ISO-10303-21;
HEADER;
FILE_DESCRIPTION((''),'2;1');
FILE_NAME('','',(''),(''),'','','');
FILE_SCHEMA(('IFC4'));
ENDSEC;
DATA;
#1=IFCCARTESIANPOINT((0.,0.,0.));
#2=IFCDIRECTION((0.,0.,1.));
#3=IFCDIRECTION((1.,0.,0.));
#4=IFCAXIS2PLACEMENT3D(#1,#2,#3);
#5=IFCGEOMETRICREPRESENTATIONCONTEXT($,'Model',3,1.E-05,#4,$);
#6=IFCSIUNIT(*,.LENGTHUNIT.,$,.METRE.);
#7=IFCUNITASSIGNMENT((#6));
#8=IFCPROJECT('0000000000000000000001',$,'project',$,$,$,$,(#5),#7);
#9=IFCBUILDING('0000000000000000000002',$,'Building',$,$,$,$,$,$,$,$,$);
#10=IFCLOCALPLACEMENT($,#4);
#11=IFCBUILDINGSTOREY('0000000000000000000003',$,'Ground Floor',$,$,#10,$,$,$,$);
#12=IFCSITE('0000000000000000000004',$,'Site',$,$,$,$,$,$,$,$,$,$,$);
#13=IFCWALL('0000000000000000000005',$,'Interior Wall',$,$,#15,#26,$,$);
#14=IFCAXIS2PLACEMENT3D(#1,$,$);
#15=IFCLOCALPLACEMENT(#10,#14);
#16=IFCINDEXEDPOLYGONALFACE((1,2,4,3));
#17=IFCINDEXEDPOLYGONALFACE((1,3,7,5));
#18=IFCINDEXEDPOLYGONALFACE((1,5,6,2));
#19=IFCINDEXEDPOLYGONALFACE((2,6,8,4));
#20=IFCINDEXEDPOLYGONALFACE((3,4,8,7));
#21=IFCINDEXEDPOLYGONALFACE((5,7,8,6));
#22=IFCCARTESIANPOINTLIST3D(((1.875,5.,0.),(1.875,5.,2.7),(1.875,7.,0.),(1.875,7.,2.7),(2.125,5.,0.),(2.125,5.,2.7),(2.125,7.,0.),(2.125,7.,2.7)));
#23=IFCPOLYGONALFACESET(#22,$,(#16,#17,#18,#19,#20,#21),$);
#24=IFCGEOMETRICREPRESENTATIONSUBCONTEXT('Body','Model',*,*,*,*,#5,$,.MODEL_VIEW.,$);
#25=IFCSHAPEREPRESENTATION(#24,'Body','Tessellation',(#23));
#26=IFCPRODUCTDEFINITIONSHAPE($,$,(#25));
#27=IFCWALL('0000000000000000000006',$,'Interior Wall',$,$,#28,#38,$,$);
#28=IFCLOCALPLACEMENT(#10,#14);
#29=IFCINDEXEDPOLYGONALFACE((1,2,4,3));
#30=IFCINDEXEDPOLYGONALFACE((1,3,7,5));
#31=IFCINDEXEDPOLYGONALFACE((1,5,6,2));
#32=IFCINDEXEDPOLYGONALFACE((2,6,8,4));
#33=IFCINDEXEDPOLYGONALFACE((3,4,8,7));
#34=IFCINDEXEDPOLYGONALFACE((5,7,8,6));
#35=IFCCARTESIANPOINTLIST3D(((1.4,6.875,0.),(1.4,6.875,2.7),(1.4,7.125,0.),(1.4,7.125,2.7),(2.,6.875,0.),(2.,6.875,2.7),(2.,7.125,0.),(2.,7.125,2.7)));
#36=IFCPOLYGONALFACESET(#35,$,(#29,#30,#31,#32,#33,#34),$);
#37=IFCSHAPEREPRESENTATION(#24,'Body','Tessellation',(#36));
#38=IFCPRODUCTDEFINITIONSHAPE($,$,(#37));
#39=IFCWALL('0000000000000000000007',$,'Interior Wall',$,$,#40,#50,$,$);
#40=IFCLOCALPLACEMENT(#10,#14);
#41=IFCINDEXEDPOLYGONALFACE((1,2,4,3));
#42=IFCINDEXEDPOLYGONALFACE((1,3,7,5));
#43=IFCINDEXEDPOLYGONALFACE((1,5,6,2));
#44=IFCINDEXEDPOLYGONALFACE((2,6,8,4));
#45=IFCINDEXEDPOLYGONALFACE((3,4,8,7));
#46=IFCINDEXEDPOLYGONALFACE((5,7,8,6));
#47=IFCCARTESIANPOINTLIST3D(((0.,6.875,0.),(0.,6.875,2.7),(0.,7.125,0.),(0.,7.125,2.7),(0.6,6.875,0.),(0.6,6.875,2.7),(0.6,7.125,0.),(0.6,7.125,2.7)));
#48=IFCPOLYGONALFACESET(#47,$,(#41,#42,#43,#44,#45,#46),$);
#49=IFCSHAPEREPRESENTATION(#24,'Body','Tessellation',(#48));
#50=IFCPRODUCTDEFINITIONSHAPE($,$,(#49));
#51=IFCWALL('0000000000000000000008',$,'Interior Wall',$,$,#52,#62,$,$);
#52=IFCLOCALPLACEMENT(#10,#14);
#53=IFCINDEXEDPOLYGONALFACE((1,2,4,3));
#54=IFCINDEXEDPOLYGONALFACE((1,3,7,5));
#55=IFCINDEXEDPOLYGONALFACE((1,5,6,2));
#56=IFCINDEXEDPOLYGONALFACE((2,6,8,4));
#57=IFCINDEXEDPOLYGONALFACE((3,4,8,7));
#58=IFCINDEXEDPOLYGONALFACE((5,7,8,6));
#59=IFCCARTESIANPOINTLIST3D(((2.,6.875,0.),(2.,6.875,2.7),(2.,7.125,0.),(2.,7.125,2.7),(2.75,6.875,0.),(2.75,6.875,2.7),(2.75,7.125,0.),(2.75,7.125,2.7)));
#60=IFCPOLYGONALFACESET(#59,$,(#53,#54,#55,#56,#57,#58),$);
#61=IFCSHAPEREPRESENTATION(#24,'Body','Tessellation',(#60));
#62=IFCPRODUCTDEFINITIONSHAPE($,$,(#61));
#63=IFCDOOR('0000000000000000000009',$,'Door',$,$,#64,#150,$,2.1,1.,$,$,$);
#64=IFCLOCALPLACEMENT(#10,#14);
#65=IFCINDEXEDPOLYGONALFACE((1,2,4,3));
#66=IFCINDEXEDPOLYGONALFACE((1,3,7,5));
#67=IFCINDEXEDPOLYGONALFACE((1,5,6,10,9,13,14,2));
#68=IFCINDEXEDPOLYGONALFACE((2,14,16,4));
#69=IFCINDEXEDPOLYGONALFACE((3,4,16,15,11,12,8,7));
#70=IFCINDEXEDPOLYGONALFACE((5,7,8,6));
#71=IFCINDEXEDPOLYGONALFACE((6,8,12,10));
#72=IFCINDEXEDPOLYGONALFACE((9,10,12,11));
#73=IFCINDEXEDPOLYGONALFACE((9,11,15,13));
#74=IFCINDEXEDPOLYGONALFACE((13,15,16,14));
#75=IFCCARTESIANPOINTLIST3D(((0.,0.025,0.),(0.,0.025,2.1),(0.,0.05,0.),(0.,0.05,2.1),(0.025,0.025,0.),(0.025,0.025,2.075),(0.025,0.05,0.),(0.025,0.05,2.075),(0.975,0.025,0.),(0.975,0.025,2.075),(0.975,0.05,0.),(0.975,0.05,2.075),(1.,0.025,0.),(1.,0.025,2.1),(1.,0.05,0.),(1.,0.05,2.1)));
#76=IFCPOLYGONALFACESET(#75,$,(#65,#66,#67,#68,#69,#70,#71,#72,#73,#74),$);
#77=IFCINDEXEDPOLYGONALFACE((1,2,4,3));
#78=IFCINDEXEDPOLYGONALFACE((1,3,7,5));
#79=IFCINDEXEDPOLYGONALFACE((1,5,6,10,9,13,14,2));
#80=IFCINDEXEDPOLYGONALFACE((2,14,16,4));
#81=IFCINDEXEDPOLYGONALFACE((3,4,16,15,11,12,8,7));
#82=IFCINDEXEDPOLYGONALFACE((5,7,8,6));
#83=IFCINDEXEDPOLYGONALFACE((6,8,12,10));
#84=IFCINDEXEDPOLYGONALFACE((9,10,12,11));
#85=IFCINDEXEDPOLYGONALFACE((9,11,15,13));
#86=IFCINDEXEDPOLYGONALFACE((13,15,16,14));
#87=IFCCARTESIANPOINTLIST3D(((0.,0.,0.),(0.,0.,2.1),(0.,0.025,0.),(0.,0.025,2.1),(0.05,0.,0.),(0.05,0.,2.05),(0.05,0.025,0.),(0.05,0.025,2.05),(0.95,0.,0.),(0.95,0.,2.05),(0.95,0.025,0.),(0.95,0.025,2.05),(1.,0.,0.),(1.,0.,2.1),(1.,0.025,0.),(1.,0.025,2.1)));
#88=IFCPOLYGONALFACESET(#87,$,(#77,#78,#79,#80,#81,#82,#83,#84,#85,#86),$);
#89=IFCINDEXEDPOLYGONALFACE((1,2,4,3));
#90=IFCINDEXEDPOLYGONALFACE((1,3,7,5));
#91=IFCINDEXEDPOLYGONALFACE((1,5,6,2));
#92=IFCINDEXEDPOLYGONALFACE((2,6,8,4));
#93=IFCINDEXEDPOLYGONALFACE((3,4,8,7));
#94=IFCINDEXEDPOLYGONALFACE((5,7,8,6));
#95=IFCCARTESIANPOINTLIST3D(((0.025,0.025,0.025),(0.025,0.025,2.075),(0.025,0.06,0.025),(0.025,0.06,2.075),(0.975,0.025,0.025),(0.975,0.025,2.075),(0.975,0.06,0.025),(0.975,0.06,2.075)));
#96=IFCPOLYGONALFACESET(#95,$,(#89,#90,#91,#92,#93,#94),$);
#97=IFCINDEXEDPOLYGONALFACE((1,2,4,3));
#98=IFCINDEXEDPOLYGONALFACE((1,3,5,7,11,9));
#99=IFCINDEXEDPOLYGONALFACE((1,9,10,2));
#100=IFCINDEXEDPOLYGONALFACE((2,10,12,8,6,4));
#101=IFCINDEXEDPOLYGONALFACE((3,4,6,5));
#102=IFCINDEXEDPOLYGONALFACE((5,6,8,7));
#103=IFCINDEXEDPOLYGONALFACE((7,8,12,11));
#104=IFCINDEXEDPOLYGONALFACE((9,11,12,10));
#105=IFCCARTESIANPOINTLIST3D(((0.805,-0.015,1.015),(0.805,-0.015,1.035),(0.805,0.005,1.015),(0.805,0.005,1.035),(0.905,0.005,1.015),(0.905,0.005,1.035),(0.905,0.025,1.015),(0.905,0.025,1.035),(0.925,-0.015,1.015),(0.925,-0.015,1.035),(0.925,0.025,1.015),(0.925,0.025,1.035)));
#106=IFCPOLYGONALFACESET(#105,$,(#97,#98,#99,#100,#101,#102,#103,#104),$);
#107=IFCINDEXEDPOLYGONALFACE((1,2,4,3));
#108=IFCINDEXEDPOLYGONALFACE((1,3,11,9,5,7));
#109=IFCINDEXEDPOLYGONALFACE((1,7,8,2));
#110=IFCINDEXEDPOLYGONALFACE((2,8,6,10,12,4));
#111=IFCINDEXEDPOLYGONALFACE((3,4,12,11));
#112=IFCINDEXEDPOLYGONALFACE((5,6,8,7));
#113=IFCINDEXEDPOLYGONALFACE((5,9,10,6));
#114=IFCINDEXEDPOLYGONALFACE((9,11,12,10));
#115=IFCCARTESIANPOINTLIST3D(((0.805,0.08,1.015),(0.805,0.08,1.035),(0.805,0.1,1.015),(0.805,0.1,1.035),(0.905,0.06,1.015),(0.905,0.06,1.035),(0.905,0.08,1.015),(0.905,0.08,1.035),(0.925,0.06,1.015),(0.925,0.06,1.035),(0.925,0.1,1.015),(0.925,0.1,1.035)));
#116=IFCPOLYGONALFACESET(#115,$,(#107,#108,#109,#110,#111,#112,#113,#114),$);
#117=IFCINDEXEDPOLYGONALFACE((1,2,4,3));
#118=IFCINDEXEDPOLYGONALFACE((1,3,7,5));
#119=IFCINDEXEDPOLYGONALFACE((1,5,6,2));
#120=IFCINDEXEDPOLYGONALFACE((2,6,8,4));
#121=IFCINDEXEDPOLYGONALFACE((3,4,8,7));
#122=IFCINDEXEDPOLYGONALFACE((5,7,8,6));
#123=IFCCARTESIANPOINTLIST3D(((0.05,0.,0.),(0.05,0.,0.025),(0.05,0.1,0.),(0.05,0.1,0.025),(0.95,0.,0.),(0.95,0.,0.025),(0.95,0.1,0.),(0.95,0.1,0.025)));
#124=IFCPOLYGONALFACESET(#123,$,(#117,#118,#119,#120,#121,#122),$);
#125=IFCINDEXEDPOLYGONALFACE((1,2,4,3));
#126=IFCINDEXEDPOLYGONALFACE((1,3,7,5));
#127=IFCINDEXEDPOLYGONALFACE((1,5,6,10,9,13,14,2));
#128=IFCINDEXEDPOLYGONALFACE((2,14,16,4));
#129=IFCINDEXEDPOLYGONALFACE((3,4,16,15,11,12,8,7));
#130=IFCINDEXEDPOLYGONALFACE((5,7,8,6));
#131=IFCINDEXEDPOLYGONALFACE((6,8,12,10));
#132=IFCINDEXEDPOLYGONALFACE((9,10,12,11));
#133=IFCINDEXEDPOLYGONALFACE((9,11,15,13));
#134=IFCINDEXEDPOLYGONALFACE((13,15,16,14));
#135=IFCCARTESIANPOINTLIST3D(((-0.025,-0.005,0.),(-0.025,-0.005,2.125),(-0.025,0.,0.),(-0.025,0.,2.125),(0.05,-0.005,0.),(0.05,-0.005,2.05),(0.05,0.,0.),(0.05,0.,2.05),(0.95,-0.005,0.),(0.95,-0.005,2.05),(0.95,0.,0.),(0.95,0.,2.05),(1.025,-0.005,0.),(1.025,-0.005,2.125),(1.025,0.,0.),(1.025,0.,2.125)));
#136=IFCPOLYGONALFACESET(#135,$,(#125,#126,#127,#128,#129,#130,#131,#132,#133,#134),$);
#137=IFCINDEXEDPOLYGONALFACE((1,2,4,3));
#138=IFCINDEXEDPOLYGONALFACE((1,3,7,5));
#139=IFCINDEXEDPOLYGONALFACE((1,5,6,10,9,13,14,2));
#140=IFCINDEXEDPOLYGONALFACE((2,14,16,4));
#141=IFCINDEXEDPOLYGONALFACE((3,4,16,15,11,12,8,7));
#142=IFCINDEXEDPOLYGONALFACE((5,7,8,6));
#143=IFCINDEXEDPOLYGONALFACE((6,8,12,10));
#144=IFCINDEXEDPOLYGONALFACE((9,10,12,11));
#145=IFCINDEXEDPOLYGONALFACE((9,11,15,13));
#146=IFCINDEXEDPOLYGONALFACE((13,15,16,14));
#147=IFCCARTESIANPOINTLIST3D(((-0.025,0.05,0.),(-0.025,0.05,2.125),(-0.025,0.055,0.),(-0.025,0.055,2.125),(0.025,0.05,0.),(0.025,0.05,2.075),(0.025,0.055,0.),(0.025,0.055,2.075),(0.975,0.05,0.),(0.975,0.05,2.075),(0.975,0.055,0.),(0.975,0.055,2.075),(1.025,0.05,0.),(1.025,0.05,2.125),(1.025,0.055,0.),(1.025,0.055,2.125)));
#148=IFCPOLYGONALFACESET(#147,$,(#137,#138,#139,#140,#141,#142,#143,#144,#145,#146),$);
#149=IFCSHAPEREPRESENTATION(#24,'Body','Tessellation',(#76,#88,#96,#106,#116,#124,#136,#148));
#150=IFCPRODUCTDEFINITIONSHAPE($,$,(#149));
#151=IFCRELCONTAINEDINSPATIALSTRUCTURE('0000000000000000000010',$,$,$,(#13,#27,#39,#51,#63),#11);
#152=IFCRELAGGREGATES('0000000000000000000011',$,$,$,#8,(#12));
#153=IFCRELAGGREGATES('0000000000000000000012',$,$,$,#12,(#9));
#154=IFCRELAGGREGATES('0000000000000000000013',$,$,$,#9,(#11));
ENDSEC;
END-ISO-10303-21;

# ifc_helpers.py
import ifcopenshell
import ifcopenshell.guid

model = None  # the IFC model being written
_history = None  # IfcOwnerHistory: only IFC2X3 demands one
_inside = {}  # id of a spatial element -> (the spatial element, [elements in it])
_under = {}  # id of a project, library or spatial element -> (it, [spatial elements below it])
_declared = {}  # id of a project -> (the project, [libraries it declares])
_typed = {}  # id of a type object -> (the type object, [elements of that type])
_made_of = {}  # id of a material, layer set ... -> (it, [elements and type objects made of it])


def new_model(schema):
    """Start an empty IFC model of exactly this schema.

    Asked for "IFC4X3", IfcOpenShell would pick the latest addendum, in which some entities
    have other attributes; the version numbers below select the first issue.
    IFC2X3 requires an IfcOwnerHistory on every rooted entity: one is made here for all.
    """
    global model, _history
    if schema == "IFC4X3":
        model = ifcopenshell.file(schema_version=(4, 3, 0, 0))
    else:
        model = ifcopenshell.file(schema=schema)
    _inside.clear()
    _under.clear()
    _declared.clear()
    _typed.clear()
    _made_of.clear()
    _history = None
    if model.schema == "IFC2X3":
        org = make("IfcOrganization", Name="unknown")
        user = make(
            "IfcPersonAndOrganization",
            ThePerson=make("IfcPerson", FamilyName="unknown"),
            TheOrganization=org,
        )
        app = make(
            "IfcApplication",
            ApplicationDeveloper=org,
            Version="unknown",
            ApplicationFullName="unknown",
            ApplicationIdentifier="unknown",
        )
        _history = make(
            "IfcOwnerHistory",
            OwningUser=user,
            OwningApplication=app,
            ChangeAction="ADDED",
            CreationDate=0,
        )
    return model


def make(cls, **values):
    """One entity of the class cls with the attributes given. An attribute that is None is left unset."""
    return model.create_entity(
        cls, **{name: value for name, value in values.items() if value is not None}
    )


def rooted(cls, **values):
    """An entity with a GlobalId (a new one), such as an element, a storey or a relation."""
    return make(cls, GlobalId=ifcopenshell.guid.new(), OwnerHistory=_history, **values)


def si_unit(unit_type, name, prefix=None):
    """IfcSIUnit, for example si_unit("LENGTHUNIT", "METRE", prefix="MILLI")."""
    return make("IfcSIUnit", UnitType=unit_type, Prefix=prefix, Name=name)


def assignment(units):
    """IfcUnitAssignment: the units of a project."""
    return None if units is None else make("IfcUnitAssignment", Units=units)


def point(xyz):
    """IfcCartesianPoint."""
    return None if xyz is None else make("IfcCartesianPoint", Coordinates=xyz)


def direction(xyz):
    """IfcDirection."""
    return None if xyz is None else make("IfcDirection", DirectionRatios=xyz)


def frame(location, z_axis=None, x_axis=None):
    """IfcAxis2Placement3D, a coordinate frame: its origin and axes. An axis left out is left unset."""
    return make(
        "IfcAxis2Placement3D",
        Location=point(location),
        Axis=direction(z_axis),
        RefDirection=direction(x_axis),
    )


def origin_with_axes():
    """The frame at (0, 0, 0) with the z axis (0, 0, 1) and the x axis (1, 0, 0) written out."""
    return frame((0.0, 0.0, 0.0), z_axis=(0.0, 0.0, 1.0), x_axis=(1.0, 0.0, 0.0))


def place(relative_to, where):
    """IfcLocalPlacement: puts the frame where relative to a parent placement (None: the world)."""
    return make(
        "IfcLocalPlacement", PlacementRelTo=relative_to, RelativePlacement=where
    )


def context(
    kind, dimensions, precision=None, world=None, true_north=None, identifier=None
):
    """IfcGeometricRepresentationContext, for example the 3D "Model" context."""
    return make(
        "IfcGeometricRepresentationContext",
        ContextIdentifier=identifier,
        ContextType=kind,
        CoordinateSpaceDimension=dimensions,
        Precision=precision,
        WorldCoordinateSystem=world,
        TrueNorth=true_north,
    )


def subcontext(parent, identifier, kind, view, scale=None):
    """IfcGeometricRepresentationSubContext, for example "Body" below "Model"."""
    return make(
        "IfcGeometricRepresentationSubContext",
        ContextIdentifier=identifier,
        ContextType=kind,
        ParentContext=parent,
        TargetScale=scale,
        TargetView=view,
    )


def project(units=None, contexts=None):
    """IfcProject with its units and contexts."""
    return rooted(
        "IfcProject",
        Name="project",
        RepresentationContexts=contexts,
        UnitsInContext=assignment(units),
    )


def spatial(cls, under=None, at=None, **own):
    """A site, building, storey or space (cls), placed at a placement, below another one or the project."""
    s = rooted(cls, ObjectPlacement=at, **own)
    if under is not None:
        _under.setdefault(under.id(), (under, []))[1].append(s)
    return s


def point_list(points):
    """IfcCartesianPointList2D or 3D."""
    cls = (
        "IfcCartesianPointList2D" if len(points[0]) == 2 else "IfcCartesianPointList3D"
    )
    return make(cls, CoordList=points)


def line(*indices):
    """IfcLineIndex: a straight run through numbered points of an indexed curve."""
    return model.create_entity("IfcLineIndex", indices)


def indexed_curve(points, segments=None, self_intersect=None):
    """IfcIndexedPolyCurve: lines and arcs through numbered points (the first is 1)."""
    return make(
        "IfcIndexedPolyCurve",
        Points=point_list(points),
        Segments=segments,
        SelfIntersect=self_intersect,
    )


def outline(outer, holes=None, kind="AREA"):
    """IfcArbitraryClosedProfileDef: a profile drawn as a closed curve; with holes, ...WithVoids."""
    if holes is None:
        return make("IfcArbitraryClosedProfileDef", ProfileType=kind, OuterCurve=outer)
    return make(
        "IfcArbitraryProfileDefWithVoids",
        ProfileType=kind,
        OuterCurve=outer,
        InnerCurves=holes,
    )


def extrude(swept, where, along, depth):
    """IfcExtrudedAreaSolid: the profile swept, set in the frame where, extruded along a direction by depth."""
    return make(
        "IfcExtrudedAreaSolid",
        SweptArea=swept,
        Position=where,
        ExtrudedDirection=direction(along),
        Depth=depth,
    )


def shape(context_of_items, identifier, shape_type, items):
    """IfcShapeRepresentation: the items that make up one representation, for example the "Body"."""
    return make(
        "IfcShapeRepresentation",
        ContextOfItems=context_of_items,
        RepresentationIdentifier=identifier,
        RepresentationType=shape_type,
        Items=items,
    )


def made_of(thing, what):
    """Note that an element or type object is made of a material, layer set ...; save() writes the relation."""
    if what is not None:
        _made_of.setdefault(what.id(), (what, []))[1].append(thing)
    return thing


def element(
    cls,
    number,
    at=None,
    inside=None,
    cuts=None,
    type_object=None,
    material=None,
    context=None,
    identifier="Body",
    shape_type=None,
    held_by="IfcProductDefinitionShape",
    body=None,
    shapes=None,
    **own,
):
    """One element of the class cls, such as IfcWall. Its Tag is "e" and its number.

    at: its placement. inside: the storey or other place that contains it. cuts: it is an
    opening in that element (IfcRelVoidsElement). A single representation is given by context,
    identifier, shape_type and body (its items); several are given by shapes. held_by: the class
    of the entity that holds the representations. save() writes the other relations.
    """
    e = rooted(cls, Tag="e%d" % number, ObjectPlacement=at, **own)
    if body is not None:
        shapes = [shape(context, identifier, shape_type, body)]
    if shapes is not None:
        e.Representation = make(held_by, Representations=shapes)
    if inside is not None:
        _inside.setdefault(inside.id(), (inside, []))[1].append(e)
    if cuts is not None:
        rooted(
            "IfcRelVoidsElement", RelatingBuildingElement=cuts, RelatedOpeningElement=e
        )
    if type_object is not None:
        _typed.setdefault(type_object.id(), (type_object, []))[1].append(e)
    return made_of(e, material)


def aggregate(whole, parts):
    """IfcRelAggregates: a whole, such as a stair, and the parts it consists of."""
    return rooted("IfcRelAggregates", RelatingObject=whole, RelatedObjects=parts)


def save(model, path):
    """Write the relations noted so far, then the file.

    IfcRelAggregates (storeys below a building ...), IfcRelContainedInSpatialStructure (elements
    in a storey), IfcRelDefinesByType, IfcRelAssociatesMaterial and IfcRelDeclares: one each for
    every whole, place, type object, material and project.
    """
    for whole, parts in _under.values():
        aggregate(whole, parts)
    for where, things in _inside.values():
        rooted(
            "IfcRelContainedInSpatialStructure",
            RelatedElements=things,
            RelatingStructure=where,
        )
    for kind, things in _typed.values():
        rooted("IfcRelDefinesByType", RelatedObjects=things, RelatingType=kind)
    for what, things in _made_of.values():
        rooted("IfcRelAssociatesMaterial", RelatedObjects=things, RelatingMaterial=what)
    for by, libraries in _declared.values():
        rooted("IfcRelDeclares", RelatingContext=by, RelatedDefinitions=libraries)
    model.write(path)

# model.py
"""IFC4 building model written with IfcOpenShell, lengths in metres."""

from ifc_helpers import new_model, si_unit, frame, origin_with_axes, place, context, subcontext, project, spatial, line, indexed_curve, outline, extrude, element, save


model = new_model("IFC4")

# Units and contexts
model_context = context("Model", 3, precision=1e-05, world=origin_with_axes())
body_context = subcontext(model_context, "Body", "Model", "MODEL_VIEW")
ifc_project = project(units=[si_unit("LENGTHUNIT", "METRE")], contexts=[model_context])

# Site, building, storey
site = spatial("IfcSite", under=ifc_project, Name="Site")
building = spatial("IfcBuilding", under=site, Name="Building")
storey_placement = place(None, origin_with_axes())
storey = spatial("IfcBuildingStorey", under=building, at=storey_placement, Name="Ground Floor")

# Walls
wall_1_placement = place(storey_placement, frame((2.0, 5.0, 0.0), z_axis=(0.0, 0.0, 1.0), x_axis=(0.0, 1.0, 0.0)))
element("IfcWall", 1, at=wall_1_placement, inside=storey, Name="Interior Wall", context=body_context, shape_type="SweptSolid", body=[
    extrude(outline(indexed_curve([(0.0, 0.0), (0.0, 0.25), (2.0, 0.25), (2.0, 0.0), (0.0, 0.0)], self_intersect=False)), frame((0.0, -0.125, 0.0), z_axis=(0.0, 0.0, 1.0), x_axis=(1.0, 0.0, 0.0)), (0.0, 0.0, 1.0), 2.7),
])
for number, where, z_axis, x_axis, name in (
    (2, (2.0, 7.0, 0.0), (0.0, 0.0, 1.0), (-1.0, 0.0, 0.0), "Interior Wall"),
    (3, (0.6, 7.0, 0.0), (0.0, 0.0, 1.0), (-1.0, 0.0, 0.0), "Interior Wall"),
):
    element("IfcWall", number, at=place(storey_placement, frame(where, z_axis=z_axis, x_axis=x_axis)), inside=storey, Name=name, context=body_context, shape_type="SweptSolid", body=[
        extrude(outline(indexed_curve([(0.0, 0.0), (0.0, 0.25), (0.6, 0.25), (0.6, 0.0), (0.0, 0.0)], self_intersect=False)), frame((0.0, -0.125, 0.0), z_axis=(0.0, 0.0, 1.0), x_axis=(1.0, 0.0, 0.0)), (0.0, 0.0, 1.0), 2.7),
    ])
wall_2_placement = place(storey_placement, frame((2.75, 7.0, 0.0), z_axis=(0.0, 0.0, 1.0), x_axis=(-1.0, 0.0, 0.0)))
element("IfcWall", 4, at=wall_2_placement, inside=storey, Name="Interior Wall", context=body_context, shape_type="SweptSolid", body=[
    extrude(outline(indexed_curve([(0.0, 0.0), (0.0, 0.25), (0.75, 0.25), (0.75, 0.0), (0.0, 0.0)], self_intersect=False)), frame((0.0, -0.125, 0.0), z_axis=(0.0, 0.0, 1.0), x_axis=(1.0, 0.0, 0.0)), (0.0, 0.0, 1.0), 2.7),
])

# Door
door_1_placement = place(storey_placement, origin_with_axes())
element("IfcDoor", 5, at=door_1_placement, inside=storey, Name="Door", OverallHeight=2.1, OverallWidth=1.0, context=body_context, shape_type="SweptSolid", body=[
    extrude(outline(indexed_curve([(0.0, 0.0), (0.0, 2.1), (1.0, 2.1), (1.0, 0.0), (0.975, 0.0), (0.975, 2.075), (0.025, 2.075), (0.025, 0.0)], segments=[line(1, 2, 3, 4, 5, 6, 7, 8, 1)])), frame((0.0, 0.025, 0.0), z_axis=(0.0, -1.0, 0.0), x_axis=(1.0, 0.0, 0.0)), (0.0, 0.0, -1.0), 0.025),
    extrude(outline(indexed_curve([(0.0, 0.0), (0.0, 2.1), (1.0, 2.1), (1.0, 0.0), (0.95, 0.0), (0.95, 2.05), (0.05, 2.05), (0.05, 0.0)], segments=[line(1, 2, 3, 4, 5, 6, 7, 8, 1)])), frame((0.0, 0.0, 0.0), z_axis=(0.0, -1.0, 0.0), x_axis=(1.0, 0.0, 0.0)), (0.0, 0.0, -1.0), 0.025),
    extrude(outline(indexed_curve([(0.0, 0.0), (0.95, 0.0), (0.95, 0.035), (0.0, 0.035)], segments=[line(1, 2, 3, 4, 1)])), frame((0.025, 0.025, 0.025), z_axis=(0.0, 0.0, 1.0), x_axis=(1.0, 0.0, 0.0)), (0.0, 0.0, 1.0), 2.05),
    extrude(outline(indexed_curve([(0.0, 0.0), (0.0, -0.04), (-0.12, -0.04), (-0.12, -0.02), (-0.02, -0.02), (-0.02, 0.0)], segments=[line(1, 2, 3, 4, 5, 6, 1)])), frame((0.925, 0.025, 1.015), z_axis=(0.0, 0.0, 1.0), x_axis=(1.0, 0.0, 0.0)), (0.0, 0.0, 1.0), 0.02),
    extrude(outline(indexed_curve([(0.0, 0.0), (0.0, 0.04), (-0.12, 0.04), (-0.12, 0.02), (-0.02, 0.02), (-0.02, 0.0)], segments=[line(1, 2, 3, 4, 5, 6, 1)])), frame((0.925, 0.06, 1.015), z_axis=(0.0, 0.0, 1.0), x_axis=(1.0, 0.0, 0.0)), (0.0, 0.0, 1.0), 0.02),
    extrude(outline(indexed_curve([(0.0, 0.0), (0.9, 0.0), (0.9, 0.1), (0.0, 0.1)], segments=[line(1, 2, 3, 4, 1)])), frame((0.05, 0.0, 0.0), z_axis=(0.0, 0.0, 1.0), x_axis=(1.0, 0.0, 0.0)), (0.0, 0.0, 1.0), 0.025),
    extrude(outline(indexed_curve([(0.0, 0.0), (0.0, 2.125), (1.05, 2.125), (1.05, 0.0), (0.975, 0.0), (0.975, 2.05), (0.075, 2.05), (0.075, 0.0)], segments=[line(1, 2, 3, 4, 5, 6, 7, 8, 1)])), frame((-0.025, -0.005, 0.0), z_axis=(0.0, -1.0, 0.0), x_axis=(1.0, 0.0, 0.0)), (0.0, 0.0, -1.0), 0.005),
    extrude(outline(indexed_curve([(0.0, 0.0), (0.0, 2.125), (1.05, 2.125), (1.05, 0.0), (1.0, 0.0), (1.0, 2.075), (0.05, 2.075), (0.05, 0.0)], segments=[line(1, 2, 3, 4, 5, 6, 7, 8, 1)])), frame((-0.025, 0.05, 0.0), z_axis=(0.0, -1.0, 0.0), x_axis=(1.0, 0.0, 0.0)), (0.0, 0.0, -1.0), 0.005),
])

save(model, "model.ifc")
